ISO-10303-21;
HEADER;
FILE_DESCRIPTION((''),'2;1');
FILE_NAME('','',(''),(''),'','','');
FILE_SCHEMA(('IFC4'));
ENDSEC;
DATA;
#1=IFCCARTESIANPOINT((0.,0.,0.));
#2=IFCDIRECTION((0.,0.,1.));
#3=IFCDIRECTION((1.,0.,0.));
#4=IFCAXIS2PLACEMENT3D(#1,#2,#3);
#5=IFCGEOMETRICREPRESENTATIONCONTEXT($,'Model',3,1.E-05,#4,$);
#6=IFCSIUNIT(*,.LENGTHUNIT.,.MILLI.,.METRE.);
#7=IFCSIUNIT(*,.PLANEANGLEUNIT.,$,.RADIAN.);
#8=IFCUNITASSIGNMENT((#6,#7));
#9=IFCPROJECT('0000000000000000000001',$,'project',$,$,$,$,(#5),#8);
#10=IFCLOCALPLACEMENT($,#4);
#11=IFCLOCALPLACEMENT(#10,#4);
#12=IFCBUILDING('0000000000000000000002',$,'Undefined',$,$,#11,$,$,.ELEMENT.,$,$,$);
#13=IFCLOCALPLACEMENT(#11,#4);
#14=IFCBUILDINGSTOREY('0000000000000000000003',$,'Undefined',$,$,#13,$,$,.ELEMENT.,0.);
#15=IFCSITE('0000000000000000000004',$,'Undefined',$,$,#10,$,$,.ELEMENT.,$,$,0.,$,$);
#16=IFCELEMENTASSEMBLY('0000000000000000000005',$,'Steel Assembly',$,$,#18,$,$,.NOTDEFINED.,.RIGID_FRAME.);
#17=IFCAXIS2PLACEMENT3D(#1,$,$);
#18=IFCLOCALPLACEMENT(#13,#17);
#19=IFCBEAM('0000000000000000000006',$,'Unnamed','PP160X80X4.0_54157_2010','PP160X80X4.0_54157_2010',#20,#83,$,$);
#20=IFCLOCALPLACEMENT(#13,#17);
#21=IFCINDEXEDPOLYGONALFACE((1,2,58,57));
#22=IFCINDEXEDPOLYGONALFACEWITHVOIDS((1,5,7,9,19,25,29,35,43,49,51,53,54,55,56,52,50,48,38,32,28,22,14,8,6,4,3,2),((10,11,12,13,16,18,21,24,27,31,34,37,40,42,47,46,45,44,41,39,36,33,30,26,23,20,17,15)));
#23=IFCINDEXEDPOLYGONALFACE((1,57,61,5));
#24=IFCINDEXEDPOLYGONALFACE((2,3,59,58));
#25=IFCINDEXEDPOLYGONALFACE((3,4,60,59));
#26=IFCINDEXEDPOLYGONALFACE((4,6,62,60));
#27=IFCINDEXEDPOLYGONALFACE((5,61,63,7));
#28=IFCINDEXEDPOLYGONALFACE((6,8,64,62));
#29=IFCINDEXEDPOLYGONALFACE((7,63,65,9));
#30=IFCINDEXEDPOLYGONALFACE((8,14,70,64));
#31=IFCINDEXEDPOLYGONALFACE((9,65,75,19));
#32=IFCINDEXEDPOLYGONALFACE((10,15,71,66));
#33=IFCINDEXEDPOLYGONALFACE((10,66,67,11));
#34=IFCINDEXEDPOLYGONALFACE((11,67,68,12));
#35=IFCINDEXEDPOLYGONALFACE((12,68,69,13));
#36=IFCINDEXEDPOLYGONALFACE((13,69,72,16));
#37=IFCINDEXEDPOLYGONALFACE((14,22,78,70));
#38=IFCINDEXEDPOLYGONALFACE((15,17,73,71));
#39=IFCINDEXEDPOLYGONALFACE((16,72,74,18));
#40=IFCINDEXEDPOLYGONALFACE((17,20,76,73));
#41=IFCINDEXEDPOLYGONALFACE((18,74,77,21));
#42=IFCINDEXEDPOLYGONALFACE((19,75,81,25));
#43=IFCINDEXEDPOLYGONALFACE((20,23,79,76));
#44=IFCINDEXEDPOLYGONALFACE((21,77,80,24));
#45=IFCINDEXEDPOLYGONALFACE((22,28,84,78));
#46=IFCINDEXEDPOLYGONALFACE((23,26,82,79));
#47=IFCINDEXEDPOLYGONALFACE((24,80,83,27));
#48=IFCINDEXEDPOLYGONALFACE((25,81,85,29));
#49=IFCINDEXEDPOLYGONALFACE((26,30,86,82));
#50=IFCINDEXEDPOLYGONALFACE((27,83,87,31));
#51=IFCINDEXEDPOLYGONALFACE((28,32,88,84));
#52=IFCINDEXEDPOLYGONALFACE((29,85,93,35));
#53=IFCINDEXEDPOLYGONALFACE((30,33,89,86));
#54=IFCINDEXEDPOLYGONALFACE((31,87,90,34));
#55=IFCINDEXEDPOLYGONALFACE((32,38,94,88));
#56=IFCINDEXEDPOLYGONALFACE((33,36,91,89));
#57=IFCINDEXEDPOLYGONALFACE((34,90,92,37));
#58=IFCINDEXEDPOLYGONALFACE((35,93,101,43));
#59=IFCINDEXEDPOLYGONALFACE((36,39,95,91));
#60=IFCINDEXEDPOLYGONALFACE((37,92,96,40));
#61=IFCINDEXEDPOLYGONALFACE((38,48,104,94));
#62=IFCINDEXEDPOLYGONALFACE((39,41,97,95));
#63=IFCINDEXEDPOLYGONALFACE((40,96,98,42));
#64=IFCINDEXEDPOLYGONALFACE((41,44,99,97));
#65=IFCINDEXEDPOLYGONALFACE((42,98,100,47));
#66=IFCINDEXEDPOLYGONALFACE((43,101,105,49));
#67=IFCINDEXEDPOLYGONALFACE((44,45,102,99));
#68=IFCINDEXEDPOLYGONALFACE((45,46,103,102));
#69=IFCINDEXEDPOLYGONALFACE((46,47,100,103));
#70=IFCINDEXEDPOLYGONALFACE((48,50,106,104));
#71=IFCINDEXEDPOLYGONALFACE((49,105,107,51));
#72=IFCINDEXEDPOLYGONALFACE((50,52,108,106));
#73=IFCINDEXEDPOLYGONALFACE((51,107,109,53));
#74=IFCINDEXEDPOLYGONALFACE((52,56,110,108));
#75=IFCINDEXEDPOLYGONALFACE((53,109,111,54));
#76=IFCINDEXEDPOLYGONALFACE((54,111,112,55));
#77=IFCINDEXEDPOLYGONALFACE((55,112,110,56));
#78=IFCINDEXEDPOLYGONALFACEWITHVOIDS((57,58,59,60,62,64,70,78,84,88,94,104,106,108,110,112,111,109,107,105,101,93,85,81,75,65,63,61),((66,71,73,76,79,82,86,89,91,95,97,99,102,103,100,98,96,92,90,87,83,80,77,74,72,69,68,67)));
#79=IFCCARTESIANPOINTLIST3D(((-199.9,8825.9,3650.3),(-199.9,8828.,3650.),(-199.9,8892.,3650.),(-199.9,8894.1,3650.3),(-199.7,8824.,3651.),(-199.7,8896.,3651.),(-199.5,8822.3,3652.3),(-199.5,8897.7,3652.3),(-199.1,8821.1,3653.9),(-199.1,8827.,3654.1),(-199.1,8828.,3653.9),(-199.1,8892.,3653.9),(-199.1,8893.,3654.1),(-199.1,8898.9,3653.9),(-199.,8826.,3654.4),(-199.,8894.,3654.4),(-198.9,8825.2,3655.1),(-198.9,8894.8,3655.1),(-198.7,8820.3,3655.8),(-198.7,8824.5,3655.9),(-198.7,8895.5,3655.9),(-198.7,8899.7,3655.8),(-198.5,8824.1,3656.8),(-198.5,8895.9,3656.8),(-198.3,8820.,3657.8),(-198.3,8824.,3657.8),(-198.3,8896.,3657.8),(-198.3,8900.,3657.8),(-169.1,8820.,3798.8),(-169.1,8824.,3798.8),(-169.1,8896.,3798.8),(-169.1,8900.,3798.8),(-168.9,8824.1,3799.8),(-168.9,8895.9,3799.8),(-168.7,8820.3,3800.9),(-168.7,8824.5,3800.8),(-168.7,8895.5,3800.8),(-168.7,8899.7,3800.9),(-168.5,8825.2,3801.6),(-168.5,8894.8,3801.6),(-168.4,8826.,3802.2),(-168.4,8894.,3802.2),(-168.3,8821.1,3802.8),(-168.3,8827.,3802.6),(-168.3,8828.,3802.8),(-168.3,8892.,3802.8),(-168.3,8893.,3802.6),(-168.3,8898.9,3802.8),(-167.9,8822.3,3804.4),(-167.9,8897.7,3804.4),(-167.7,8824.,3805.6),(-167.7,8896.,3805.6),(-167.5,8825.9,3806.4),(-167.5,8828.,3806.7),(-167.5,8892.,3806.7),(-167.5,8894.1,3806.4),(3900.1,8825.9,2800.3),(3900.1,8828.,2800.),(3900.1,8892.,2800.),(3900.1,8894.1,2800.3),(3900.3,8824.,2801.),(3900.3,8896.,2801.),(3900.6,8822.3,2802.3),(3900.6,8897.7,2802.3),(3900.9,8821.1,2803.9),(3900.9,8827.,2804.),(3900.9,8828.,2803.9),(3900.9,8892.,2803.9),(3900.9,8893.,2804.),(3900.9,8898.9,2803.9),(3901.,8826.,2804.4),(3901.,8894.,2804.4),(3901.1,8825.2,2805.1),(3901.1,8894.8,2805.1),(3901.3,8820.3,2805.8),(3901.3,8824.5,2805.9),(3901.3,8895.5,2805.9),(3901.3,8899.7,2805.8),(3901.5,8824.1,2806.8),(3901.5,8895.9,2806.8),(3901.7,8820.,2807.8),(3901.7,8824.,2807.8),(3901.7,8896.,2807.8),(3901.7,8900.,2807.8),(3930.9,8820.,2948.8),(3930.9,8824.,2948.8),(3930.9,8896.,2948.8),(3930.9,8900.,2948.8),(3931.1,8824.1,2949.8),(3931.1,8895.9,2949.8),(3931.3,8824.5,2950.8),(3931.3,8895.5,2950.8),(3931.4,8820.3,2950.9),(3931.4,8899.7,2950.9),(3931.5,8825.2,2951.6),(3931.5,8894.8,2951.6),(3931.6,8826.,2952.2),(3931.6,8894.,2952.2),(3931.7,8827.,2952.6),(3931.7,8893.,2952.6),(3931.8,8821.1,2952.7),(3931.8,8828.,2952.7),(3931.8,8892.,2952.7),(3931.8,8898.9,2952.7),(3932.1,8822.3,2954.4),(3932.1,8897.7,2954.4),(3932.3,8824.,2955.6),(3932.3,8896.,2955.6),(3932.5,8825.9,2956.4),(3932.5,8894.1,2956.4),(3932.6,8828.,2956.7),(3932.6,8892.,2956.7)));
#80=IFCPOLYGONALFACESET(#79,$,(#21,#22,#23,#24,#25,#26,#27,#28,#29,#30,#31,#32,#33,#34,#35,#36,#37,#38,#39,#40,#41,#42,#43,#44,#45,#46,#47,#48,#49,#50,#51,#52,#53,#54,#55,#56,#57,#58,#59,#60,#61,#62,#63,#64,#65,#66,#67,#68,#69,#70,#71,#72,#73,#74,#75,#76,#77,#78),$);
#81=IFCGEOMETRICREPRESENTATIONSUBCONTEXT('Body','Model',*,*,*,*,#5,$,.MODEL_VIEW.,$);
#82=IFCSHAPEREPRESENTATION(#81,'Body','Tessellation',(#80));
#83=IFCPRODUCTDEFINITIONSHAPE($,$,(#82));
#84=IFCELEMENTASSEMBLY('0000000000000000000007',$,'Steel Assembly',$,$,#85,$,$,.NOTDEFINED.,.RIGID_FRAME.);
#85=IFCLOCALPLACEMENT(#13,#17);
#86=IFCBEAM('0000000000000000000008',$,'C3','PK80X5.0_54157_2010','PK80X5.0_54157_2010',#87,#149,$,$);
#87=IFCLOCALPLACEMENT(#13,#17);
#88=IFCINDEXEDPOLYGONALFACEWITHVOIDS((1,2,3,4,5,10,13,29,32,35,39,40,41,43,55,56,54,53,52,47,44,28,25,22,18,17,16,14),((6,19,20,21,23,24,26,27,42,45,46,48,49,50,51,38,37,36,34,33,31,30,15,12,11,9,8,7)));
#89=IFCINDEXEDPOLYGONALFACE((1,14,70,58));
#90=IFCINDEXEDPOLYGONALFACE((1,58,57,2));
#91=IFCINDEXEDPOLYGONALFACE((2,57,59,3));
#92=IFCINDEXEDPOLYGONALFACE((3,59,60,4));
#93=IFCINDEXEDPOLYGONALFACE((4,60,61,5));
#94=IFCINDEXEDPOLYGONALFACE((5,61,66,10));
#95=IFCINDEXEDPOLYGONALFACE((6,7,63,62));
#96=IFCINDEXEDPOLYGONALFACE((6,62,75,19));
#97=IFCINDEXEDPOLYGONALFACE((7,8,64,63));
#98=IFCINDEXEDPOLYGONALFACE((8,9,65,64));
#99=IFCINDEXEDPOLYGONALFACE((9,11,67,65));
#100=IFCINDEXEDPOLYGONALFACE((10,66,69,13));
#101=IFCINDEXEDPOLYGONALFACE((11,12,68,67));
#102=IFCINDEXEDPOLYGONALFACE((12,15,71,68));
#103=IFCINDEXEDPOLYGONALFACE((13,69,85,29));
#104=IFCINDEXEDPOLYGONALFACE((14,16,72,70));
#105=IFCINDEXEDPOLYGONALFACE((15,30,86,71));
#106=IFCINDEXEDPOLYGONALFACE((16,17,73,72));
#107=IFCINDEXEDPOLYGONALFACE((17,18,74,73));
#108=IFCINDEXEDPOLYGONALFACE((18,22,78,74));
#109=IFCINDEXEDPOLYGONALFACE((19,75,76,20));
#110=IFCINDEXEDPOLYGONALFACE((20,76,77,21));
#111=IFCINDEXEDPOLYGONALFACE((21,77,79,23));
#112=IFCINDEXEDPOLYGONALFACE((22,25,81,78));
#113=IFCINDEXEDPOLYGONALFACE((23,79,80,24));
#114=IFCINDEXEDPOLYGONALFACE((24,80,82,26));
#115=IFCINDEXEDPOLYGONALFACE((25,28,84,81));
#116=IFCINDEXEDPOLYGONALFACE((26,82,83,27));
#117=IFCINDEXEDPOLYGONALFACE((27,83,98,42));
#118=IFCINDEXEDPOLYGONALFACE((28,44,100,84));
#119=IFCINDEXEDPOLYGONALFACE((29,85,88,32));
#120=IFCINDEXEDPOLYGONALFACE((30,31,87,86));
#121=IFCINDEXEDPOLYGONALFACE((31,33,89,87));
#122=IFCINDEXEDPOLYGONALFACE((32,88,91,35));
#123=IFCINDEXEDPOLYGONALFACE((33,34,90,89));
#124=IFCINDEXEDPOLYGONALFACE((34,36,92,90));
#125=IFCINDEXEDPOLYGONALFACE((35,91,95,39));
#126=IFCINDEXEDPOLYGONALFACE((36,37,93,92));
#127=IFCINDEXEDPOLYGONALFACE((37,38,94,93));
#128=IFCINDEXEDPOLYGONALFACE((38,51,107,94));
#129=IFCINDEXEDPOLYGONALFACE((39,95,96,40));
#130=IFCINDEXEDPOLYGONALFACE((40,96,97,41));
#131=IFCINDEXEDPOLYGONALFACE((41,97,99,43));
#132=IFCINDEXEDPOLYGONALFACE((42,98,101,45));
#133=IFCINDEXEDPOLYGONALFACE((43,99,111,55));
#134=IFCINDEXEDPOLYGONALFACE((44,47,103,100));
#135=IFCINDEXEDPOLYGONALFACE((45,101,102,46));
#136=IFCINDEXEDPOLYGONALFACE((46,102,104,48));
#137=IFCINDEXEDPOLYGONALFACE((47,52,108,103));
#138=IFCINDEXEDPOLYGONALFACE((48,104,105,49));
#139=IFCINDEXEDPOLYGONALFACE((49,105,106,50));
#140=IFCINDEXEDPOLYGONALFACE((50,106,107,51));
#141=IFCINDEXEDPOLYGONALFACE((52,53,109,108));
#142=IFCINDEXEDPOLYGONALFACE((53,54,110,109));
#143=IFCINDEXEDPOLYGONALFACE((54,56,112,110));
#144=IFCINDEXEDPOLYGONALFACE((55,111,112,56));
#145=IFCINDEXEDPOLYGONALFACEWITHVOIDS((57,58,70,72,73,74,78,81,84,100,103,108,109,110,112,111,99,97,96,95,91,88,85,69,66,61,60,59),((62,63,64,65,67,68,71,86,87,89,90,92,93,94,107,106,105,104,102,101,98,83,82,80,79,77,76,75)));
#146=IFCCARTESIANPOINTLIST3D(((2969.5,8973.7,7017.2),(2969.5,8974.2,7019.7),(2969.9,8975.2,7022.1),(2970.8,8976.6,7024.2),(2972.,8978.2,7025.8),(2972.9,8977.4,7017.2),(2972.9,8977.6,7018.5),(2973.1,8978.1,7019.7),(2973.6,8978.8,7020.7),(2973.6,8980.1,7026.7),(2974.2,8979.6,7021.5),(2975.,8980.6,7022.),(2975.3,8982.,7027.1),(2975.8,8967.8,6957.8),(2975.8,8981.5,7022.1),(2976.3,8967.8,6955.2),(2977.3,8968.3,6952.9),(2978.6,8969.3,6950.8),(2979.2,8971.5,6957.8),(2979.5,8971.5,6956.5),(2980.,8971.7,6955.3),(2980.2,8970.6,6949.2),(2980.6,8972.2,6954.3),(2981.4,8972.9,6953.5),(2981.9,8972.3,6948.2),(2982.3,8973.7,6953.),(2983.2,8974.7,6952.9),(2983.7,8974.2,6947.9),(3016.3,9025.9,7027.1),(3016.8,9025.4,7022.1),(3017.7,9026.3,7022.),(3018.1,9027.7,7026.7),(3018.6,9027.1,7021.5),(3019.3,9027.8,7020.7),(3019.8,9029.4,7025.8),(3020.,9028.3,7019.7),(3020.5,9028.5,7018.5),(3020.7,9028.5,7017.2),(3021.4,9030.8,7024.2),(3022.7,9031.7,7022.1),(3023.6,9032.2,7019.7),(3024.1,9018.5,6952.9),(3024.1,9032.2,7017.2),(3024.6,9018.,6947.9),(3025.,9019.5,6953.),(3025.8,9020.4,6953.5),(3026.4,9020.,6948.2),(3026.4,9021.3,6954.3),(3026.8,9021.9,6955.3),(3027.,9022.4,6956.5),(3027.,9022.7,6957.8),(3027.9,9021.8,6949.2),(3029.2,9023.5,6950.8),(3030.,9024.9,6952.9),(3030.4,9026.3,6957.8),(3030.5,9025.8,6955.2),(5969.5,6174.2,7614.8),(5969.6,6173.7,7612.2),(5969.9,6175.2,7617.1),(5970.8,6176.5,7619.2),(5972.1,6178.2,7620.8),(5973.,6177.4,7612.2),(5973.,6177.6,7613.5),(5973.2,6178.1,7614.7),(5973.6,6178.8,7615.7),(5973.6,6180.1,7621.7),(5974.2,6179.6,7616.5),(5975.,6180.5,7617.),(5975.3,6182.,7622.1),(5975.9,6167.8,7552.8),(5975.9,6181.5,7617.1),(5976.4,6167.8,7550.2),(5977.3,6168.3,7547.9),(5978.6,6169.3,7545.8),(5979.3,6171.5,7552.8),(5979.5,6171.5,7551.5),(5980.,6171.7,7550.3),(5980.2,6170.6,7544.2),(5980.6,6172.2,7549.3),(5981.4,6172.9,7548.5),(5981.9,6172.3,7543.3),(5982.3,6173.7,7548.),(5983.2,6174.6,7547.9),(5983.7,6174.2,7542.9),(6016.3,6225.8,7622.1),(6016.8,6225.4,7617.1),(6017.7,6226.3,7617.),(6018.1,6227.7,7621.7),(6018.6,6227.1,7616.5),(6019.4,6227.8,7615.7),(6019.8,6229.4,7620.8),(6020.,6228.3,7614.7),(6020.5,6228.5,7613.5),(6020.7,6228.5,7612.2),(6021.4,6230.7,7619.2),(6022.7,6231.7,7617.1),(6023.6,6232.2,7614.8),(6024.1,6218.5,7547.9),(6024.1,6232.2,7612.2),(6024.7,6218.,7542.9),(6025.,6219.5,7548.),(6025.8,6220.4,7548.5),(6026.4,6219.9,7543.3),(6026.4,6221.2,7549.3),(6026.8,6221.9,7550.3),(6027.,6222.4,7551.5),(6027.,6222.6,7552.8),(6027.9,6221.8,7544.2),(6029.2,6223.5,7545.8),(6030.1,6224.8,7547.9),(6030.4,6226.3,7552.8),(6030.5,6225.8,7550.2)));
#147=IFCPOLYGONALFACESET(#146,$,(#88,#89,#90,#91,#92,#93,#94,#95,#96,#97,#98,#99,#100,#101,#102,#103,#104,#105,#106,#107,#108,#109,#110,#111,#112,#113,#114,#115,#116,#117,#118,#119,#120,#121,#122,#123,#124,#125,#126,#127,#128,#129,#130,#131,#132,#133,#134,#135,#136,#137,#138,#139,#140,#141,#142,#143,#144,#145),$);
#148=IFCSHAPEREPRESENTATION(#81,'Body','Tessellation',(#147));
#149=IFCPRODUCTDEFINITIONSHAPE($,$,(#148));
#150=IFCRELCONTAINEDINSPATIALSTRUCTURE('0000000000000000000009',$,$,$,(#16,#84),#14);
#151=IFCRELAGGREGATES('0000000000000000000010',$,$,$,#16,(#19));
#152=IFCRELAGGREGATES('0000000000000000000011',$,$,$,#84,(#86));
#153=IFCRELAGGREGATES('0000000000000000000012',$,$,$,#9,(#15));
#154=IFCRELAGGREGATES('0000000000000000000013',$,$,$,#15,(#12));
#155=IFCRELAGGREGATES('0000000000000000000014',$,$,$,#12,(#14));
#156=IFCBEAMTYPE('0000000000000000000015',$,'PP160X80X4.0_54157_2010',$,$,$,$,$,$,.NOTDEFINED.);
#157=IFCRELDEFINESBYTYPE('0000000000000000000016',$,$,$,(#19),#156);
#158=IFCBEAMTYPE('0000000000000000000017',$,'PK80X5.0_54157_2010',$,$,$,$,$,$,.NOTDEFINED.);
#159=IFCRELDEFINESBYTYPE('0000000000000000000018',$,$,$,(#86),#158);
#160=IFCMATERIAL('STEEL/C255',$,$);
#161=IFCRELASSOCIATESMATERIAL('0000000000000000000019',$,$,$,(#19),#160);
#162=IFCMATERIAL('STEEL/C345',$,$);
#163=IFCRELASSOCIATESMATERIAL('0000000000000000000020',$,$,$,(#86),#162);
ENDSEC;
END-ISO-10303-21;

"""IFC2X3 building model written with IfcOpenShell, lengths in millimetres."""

from ifc_helpers import new_model, si_unit, frame, origin_with_axes, origin_2d_with_axis, place, context, subcontext, project, spatial, hollow_rectangle, extrude, material, type_object, element, aggregate, save


model = new_model("IFC2X3")

# Units and contexts
model_context = context("Model", 3, precision=1e-05, world=origin_with_axes())
body_context = subcontext(model_context, "Body", "Model", "MODEL_VIEW")
ifc_project = project(units=[si_unit("LENGTHUNIT", "METRE", prefix="MILLI"), si_unit("PLANEANGLEUNIT", "RADIAN")], contexts=[model_context])

# Site, building, storey
site_placement = place(None, origin_with_axes())
site = spatial("IfcSite", under=ifc_project, at=site_placement, Name="Undefined", CompositionType="ELEMENT", RefElevation=0.0)
building_placement = place(site_placement, origin_with_axes())
building = spatial("IfcBuilding", under=site, at=building_placement, Name="Undefined", CompositionType="ELEMENT")
storey_placement = place(building_placement, origin_with_axes())
storey = spatial("IfcBuildingStorey", under=building, at=storey_placement, Name="Undefined", CompositionType="ELEMENT", Elevation=0.0)

# Element assemblies, beams
ifc_material_1 = material(Name="STEEL/C345")
ifc_material_2 = material(Name="STEEL/C255")
beam_type_1 = type_object("IfcBeamType", Name="PP160X80X4.0_54157_2010", PredefinedType="NOTDEFINED")
assembly_1_placement = place(storey_placement, origin_with_axes())
assembly_1 = element("IfcElementAssembly", 1, at=assembly_1_placement, inside=storey, Name="Steel Assembly", AssemblyPlace="NOTDEFINED", PredefinedType="RIGID_FRAME")
beam_1_placement = place(assembly_1_placement, frame((3916.3, 8860.0, 2878.3), z_axis=(0.203, 0.0, 0.979179), x_axis=(-0.979179, 0.0, 0.203)))
beam_1 = element("IfcBeam", 2, at=beam_1_placement, type_object=beam_type_1, material=ifc_material_2, Name="Unnamed", Description="PP160X80X4.0_54157_2010", ObjectType="PP160X80X4.0_54157_2010", context=body_context, shape_type="SweptSolid", body=[
    extrude(hollow_rectangle(XDim=80.0, YDim=160.0, WallThickness=4.0, InnerFilletRadius=4.0, OuterFilletRadius=8.0, at=origin_2d_with_axis()), frame((4187.2, 0.0, 0.0), z_axis=(-1.0, 0.0, 0.0), x_axis=(0.0, -1.0, 0.0)), (0.0, 0.0, 1.0), 4187.2),
])
aggregate(assembly_1, [beam_1])
assembly_2_placement = place(storey_placement, origin_with_axes())
assembly_2 = element("IfcElementAssembly", 3, at=assembly_2_placement, inside=storey, Name="Steel Assembly", AssemblyPlace="NOTDEFINED", PredefinedType="RIGID_FRAME")
beam_type_2 = type_object("IfcBeamType", Name="PK80X5.0_54157_2010", PredefinedType="NOTDEFINED")
beam_2_placement = place(assembly_2_placement, frame((3000.0, 9000.0, 6987.5), z_axis=(-0.104901, 0.097907, 0.989651), x_axis=(0.72349, -0.675257, 0.143492)))
beam_2 = element("IfcBeam", 4, at=beam_2_placement, type_object=beam_type_2, material=ifc_material_1, Name="C3", Description="PK80X5.0_54157_2010", ObjectType="PK80X5.0_54157_2010", context=body_context, shape_type="SweptSolid", body=[
    extrude(hollow_rectangle(XDim=80.0, YDim=80.0, WallThickness=5.0, InnerFilletRadius=5.0, OuterFilletRadius=10.0, at=origin_2d_with_axis()), frame((4146.6, 0.0, 0.0), z_axis=(-1.0, 0.0, 0.0), x_axis=(0.0, -1.0, 0.0)), (0.0, 0.0, 1.0), 4146.6),
])
aggregate(assembly_2, [beam_2])

save(model, "model.ifc")
